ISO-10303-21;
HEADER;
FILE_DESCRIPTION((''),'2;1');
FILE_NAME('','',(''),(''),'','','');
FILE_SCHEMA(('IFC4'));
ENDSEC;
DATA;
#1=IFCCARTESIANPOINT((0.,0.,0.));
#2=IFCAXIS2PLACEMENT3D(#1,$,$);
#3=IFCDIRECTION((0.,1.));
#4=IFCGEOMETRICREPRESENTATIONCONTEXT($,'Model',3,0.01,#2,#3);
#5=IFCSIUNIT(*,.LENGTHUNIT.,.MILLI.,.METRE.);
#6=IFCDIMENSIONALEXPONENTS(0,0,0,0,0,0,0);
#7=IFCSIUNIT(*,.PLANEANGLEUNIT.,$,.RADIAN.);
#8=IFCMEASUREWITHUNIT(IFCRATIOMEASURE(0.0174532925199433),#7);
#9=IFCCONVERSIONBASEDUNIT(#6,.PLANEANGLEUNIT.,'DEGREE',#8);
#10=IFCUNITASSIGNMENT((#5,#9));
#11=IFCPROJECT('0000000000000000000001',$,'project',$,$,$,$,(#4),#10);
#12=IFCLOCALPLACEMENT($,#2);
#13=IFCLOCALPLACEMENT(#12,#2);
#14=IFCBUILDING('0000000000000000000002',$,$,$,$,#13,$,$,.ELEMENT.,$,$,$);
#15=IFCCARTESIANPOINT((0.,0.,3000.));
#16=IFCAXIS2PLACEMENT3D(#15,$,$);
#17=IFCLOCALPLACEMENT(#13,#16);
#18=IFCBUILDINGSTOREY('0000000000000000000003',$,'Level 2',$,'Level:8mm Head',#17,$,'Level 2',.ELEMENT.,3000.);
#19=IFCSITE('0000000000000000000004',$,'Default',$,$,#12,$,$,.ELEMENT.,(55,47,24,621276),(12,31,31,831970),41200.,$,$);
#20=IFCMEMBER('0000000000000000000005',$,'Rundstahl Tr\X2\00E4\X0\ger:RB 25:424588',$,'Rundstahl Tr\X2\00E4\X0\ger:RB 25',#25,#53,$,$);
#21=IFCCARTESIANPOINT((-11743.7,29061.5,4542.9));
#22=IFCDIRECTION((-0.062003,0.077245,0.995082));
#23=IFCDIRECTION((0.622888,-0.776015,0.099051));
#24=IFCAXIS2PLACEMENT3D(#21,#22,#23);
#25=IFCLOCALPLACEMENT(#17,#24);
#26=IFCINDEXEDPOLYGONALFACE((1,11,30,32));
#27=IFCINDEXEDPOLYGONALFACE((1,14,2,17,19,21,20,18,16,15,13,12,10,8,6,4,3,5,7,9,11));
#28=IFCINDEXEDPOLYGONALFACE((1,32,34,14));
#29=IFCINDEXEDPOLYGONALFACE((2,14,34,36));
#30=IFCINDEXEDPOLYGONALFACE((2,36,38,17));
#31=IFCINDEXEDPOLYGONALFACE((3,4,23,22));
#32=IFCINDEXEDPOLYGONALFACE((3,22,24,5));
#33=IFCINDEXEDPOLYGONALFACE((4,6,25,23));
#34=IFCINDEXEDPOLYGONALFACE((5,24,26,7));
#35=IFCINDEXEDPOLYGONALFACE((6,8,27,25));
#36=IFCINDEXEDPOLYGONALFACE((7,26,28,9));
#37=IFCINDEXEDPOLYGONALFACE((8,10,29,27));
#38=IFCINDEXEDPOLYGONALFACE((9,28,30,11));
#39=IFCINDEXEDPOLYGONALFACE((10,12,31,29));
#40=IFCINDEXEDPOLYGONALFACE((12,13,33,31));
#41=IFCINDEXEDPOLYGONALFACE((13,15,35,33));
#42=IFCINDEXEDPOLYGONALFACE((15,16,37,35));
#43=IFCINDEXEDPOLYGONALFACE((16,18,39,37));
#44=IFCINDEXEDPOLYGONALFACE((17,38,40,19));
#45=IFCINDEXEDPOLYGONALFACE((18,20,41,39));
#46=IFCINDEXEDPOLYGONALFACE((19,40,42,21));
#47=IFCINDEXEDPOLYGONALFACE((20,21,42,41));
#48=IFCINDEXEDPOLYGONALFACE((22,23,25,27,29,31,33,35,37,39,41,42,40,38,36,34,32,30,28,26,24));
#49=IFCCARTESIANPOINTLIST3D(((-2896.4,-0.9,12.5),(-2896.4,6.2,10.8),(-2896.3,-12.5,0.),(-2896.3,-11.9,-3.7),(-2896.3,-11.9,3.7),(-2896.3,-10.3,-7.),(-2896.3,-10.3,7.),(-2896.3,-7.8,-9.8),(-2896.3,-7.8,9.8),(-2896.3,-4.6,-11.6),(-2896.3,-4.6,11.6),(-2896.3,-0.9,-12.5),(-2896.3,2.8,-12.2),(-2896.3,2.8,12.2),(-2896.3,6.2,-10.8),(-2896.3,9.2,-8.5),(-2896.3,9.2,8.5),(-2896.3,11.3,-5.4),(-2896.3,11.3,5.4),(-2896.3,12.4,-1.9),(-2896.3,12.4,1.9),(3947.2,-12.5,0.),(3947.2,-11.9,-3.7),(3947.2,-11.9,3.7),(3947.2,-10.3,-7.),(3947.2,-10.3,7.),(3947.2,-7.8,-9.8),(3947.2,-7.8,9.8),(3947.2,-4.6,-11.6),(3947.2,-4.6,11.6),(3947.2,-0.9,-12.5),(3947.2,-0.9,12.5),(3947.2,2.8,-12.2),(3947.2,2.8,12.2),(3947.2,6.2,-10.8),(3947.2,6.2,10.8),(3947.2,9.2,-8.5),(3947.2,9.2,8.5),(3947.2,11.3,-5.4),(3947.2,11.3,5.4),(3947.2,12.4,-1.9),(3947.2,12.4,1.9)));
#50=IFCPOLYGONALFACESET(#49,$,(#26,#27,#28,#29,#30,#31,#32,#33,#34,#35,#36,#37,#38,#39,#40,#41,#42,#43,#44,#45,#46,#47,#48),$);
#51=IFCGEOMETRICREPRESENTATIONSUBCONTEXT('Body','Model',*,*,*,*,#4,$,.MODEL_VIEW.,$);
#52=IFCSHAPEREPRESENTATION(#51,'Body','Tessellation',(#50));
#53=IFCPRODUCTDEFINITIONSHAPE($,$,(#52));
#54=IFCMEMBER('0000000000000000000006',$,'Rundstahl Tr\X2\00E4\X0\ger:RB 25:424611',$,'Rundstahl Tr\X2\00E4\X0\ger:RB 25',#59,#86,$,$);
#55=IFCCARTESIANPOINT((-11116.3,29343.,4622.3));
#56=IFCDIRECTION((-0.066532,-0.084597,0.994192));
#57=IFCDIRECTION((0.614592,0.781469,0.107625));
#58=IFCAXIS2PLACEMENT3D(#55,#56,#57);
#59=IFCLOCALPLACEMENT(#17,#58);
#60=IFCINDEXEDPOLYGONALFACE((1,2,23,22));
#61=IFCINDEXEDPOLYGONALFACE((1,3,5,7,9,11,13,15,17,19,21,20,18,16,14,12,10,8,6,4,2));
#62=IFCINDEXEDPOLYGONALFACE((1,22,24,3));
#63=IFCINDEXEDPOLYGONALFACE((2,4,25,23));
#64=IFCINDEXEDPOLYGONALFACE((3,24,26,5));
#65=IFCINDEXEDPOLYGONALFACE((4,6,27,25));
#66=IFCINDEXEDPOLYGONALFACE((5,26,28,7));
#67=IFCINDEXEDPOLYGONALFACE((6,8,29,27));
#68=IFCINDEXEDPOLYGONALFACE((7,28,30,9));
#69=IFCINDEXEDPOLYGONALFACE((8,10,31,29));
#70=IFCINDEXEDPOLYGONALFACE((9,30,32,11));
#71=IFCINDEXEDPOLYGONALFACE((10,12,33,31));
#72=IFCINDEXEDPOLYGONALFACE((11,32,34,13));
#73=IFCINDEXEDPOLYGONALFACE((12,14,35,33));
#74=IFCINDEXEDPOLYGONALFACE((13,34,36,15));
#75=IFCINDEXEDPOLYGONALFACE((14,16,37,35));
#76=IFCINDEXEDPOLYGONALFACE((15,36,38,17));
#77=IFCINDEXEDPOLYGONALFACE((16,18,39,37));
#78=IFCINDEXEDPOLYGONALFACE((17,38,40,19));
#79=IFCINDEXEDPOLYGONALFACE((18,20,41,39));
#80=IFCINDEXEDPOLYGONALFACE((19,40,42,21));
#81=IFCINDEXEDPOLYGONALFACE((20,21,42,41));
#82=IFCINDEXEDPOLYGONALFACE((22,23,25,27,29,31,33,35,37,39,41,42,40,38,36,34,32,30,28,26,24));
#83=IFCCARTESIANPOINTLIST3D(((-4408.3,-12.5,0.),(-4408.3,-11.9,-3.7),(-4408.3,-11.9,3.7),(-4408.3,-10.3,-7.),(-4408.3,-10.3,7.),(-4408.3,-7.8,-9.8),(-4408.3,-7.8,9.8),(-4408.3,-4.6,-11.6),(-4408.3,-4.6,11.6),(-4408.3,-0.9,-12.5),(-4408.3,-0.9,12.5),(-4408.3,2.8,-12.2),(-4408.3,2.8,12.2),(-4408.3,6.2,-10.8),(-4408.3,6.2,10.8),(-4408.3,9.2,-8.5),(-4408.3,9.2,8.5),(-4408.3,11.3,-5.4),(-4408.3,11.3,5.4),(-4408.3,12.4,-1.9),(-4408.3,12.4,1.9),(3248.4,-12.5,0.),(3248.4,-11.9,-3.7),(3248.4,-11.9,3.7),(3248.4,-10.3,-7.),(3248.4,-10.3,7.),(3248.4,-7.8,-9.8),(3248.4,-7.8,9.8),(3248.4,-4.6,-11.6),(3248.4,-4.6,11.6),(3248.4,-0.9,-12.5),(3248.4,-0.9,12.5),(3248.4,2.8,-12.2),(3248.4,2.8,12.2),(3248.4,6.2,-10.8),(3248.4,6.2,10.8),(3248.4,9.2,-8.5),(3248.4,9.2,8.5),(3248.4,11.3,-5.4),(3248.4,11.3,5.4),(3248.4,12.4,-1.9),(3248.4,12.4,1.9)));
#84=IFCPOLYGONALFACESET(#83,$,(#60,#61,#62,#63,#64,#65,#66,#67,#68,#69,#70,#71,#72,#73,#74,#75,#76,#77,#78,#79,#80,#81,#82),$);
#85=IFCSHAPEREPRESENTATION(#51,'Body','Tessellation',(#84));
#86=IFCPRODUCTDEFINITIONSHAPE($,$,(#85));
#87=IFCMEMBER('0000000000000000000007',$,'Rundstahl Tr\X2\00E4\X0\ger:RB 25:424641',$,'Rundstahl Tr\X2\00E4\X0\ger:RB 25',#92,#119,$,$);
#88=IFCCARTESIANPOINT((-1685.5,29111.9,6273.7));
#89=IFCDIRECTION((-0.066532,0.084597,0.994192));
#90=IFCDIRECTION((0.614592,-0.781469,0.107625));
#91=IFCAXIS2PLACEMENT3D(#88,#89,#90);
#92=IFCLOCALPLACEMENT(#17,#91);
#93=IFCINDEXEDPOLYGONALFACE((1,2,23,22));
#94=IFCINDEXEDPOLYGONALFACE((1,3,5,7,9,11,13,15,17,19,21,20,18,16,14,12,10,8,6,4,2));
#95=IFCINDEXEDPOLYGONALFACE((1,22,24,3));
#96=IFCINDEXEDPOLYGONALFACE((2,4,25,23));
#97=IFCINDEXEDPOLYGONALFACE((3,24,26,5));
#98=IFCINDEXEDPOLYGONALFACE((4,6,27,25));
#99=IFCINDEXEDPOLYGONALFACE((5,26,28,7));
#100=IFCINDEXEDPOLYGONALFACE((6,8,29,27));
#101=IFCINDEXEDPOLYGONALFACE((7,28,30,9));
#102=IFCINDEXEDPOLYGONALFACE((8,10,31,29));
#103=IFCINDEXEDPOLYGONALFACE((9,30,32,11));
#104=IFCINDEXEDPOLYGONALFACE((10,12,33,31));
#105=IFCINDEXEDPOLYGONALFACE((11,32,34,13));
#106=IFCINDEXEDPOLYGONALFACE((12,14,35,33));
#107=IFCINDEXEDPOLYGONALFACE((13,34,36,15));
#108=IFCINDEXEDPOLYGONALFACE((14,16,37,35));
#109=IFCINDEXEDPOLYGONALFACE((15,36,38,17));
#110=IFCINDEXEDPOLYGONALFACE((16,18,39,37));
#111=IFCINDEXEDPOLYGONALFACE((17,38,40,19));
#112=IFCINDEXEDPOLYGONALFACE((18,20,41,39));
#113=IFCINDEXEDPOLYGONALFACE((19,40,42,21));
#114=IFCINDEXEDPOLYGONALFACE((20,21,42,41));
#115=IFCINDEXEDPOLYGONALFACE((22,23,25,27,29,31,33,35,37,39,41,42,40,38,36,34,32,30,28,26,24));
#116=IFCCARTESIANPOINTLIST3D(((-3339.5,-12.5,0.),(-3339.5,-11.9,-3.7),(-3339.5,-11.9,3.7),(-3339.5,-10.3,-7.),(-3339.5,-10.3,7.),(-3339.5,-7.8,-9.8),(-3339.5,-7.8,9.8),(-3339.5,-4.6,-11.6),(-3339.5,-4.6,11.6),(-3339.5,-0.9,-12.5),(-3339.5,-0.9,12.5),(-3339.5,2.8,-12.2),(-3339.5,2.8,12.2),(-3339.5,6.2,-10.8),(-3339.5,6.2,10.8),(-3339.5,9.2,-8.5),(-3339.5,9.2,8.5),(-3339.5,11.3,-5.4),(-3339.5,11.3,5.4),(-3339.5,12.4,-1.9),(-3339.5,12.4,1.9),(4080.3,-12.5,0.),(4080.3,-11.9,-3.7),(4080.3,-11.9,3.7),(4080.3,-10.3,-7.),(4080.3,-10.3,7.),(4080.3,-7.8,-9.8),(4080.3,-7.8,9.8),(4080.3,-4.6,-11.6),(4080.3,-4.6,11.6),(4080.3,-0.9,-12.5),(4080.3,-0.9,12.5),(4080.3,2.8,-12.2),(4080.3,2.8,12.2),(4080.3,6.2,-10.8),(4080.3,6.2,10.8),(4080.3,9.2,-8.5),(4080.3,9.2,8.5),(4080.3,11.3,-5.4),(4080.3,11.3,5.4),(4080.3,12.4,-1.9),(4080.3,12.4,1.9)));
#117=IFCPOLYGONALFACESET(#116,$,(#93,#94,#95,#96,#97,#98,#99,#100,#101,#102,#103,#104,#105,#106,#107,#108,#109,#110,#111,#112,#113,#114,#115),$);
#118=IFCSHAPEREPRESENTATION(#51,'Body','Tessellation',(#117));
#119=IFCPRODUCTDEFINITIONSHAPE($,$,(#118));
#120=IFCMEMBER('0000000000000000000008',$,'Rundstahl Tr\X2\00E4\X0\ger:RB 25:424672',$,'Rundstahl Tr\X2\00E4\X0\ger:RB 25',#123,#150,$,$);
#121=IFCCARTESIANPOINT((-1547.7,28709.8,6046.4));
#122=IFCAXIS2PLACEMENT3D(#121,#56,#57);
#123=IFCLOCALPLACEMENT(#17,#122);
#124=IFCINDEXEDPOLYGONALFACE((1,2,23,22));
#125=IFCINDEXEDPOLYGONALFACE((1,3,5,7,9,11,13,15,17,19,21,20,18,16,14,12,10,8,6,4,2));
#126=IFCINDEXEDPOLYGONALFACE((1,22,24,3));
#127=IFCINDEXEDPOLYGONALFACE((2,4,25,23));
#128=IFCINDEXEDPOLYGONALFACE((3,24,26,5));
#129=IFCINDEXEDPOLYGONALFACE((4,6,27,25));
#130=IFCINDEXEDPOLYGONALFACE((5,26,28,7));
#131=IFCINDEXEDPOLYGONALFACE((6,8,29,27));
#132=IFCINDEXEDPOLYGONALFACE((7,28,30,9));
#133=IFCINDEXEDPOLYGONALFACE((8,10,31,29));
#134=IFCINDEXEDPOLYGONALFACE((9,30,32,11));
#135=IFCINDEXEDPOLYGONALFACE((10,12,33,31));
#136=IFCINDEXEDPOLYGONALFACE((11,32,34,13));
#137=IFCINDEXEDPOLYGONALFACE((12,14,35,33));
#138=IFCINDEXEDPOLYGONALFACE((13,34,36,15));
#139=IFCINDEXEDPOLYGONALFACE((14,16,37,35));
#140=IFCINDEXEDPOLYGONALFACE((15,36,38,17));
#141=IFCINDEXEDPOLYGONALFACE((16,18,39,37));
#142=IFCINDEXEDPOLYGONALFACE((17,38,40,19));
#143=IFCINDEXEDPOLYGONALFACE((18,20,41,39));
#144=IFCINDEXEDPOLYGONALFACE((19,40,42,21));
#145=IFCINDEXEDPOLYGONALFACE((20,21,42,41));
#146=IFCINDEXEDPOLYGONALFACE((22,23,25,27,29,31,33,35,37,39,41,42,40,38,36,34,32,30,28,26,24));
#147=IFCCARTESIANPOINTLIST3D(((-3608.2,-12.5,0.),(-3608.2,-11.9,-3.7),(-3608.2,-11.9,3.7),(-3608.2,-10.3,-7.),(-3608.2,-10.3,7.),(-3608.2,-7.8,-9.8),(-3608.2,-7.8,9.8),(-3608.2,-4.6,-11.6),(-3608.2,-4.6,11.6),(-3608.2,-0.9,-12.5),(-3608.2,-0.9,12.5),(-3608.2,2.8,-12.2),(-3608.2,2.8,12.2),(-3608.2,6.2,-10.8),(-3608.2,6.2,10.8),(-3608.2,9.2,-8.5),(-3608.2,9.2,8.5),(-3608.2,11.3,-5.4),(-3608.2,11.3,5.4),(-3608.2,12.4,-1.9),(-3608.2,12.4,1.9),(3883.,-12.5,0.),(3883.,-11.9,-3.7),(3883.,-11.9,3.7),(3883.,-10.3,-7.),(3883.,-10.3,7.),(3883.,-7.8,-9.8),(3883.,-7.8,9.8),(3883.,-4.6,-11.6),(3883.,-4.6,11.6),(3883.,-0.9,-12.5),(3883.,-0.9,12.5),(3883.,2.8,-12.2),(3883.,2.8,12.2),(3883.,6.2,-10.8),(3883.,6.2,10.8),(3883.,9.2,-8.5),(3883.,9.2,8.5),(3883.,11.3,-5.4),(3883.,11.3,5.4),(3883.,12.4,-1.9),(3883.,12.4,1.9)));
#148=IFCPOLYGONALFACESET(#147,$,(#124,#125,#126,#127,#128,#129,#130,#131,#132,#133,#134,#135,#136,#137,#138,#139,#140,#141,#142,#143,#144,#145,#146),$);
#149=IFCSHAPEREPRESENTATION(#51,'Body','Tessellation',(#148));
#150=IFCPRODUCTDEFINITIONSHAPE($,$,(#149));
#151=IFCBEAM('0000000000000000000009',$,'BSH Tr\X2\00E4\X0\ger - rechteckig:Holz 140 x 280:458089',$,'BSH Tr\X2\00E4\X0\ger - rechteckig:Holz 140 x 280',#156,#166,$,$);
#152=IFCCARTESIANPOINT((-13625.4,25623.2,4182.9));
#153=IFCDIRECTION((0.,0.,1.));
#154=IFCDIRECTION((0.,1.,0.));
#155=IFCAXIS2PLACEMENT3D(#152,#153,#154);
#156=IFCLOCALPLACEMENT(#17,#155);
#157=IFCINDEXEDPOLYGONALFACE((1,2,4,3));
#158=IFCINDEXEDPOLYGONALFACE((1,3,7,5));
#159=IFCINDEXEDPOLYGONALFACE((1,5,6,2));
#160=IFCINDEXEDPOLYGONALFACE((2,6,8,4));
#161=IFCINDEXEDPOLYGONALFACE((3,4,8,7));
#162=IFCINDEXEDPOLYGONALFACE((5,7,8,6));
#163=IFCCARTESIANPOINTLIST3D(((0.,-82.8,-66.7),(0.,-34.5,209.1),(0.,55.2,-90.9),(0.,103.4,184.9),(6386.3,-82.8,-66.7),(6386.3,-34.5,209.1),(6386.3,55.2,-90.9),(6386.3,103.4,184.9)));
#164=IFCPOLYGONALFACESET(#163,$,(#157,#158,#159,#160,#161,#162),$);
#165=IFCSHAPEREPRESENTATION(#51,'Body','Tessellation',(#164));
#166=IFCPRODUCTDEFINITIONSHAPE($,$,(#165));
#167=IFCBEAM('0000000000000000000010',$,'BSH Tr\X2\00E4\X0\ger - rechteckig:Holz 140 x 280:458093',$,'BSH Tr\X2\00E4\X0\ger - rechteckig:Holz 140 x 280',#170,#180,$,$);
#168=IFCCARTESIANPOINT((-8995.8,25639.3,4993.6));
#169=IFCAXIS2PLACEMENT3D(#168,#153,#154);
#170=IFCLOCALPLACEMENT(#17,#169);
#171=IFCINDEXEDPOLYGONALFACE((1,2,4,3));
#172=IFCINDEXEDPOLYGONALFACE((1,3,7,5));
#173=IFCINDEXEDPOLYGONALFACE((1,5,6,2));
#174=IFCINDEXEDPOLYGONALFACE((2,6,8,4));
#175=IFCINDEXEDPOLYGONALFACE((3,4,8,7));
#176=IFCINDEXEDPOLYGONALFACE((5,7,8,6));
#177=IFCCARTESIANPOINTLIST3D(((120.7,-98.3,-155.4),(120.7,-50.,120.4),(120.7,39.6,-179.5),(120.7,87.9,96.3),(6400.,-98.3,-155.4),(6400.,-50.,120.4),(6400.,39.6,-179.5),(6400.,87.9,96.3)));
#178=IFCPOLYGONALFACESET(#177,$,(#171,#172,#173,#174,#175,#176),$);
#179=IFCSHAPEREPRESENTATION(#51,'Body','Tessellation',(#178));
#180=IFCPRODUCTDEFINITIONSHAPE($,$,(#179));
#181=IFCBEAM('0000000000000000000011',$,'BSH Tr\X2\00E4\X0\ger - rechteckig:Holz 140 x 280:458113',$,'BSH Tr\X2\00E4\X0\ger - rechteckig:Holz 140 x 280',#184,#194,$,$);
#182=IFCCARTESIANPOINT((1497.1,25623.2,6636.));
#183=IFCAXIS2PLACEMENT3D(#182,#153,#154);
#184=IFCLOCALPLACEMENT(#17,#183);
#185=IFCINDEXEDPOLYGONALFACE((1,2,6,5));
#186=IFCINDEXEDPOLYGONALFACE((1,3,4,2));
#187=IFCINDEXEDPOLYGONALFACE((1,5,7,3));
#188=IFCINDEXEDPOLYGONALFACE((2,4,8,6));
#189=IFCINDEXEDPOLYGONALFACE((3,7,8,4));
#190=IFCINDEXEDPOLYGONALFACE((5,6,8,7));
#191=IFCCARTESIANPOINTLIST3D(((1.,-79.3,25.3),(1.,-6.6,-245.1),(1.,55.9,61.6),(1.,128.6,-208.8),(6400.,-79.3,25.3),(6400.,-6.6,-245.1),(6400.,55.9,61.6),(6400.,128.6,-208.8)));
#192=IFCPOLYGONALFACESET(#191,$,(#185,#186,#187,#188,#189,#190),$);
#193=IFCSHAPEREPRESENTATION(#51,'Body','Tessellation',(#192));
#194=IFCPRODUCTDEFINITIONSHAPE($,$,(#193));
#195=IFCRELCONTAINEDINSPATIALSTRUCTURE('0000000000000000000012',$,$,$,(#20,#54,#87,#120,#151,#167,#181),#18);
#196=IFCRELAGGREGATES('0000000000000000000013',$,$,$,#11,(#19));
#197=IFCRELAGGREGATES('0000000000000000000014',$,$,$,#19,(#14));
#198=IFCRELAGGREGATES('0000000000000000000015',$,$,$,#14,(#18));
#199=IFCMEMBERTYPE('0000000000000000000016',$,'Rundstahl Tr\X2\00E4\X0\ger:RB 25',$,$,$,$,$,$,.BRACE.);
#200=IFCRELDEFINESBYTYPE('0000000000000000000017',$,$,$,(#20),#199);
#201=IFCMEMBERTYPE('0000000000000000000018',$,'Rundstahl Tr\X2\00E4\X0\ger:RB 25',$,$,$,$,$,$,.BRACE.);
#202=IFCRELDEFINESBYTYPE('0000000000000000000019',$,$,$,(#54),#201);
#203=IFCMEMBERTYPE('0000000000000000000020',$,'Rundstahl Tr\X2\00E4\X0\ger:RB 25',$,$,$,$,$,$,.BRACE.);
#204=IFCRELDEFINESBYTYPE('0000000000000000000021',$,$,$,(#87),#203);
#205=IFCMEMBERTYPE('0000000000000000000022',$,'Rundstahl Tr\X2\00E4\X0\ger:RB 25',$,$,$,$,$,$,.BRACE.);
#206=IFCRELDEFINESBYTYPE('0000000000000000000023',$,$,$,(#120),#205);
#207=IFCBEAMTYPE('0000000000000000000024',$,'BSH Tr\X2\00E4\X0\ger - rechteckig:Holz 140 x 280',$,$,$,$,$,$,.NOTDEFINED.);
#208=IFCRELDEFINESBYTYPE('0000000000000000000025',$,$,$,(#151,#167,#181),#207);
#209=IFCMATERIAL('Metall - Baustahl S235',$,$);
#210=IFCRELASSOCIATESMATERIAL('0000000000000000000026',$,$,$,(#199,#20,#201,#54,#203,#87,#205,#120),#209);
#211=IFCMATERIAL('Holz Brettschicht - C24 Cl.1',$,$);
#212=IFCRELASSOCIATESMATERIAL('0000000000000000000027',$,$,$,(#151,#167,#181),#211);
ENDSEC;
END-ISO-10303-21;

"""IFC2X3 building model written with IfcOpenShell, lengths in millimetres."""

from ifc_helpers import new_model, entity, si_unit, converted_unit, direction, frame, frame_2d, origin, origin_2d_with_axis, place, context, subcontext, project, spatial, rectangle, circle, extrude, source, transform, mapped, material, type_object, type_shapes, element, save


model = new_model("IFC2X3")

# Units and contexts
model_context = context("Model", 3, precision=0.01, world=origin(), true_north=direction((0.0, 1.0)))
body_context = subcontext(model_context, "Body", "Model", "MODEL_VIEW")
ifc_project = project(units=[si_unit("LENGTHUNIT", "METRE", prefix="MILLI"), converted_unit("PLANEANGLEUNIT", "DEGREE", entity("IfcRatioMeasure", 0.0174532925199433), si_unit("PLANEANGLEUNIT", "RADIAN"), dimensions=[0, 0, 0, 0, 0, 0, 0])], contexts=[model_context])

# Site, building, storey
site_placement = place(None, origin())
site = spatial("IfcSite", under=ifc_project, at=site_placement, Name="Default", CompositionType="ELEMENT", RefLatitude=(55, 47, 24, 621276), RefLongitude=(12, 31, 31, 831970), RefElevation=41200.0)
building_placement = place(site_placement, origin())
building = spatial("IfcBuilding", under=site, at=building_placement, CompositionType="ELEMENT")
storey_placement = place(building_placement, frame((0.0, 0.0, 3000.0)))
storey = spatial("IfcBuildingStorey", under=building, at=storey_placement, Name="Level 2", ObjectType="Level:8mm Head", LongName="Level 2", CompositionType="ELEMENT", Elevation=3000.0)

# Shared definitions
ifc_material_1 = material(Name="Holz Brettschicht - C24 Cl.1")
ifc_material_2 = material(Name="Metall - Baustahl S235")

# Members
member_type_1 = type_object("IfcMemberType", Name="Rundstahl Träger:RB 25", PredefinedType="BRACE", material=ifc_material_2)
shared_shape_1 = source(origin(), body_context, "Body", "SweptSolid", [
    extrude(circle(Radius=12.5, at=frame_2d((0.0, 0.0), x_axis=(1.0, 0.0))), frame((-2896.3, 0.0, 0.0), z_axis=(1.0, 0.0, 0.0), x_axis=(0.0, -1.0, 0.0)), (0.0, 0.0, 1.0), 6843.6),
])
type_shapes(member_type_1, [shared_shape_1])
member_1_placement = place(storey_placement, frame((-11743.7, 29061.5, 4542.9), z_axis=(-0.062003, 0.077245, 0.995082), x_axis=(0.622888, -0.776015, 0.099051)))
element("IfcMember", 1, at=member_1_placement, inside=storey, type_object=member_type_1, material=ifc_material_2, Name="Rundstahl Träger:RB 25:424588", ObjectType="Rundstahl Träger:RB 25", context=body_context, shape_type="MappedRepresentation", body=[
    mapped(shared_shape_1, transform((0.0, 0.0, 0.0), scale=1.0)),
])
member_type_2 = type_object("IfcMemberType", Name="Rundstahl Träger:RB 25", PredefinedType="BRACE", material=ifc_material_2)
shared_shape_2 = source(origin(), body_context, "Body", "SweptSolid", [
    extrude(circle(Radius=12.5, at=frame_2d((0.0, 0.0), x_axis=(1.0, 0.0))), frame((-4408.3, 0.0, 0.0), z_axis=(1.0, 0.0, 0.0), x_axis=(0.0, -1.0, 0.0)), (0.0, 0.0, 1.0), 7656.7),
])
type_shapes(member_type_2, [shared_shape_2])
member_2_placement = place(storey_placement, frame((-11116.3, 29343.0, 4622.3), z_axis=(-0.066532, -0.084597, 0.994192), x_axis=(0.614592, 0.781469, 0.107625)))
element("IfcMember", 2, at=member_2_placement, inside=storey, type_object=member_type_2, material=ifc_material_2, Name="Rundstahl Träger:RB 25:424611", ObjectType="Rundstahl Träger:RB 25", context=body_context, shape_type="MappedRepresentation", body=[
    mapped(shared_shape_2, transform((0.0, 0.0, 0.0), scale=1.0)),
])
member_type_3 = type_object("IfcMemberType", Name="Rundstahl Träger:RB 25", PredefinedType="BRACE", material=ifc_material_2)
shared_shape_3 = source(origin(), body_context, "Body", "SweptSolid", [
    extrude(circle(Radius=12.5, at=frame_2d((0.0, 0.0), x_axis=(1.0, 0.0))), frame((-3339.5, 0.0, 0.0), z_axis=(1.0, 0.0, 0.0), x_axis=(0.0, -1.0, 0.0)), (0.0, 0.0, 1.0), 7419.7),
])
type_shapes(member_type_3, [shared_shape_3])
member_3_placement = place(storey_placement, frame((-1685.5, 29111.9, 6273.7), z_axis=(-0.066532, 0.084597, 0.994192), x_axis=(0.614592, -0.781469, 0.107625)))
element("IfcMember", 3, at=member_3_placement, inside=storey, type_object=member_type_3, material=ifc_material_2, Name="Rundstahl Träger:RB 25:424641", ObjectType="Rundstahl Träger:RB 25", context=body_context, shape_type="MappedRepresentation", body=[
    mapped(shared_shape_3, transform((0.0, 0.0, 0.0), scale=1.0)),
])
member_type_4 = type_object("IfcMemberType", Name="Rundstahl Träger:RB 25", PredefinedType="BRACE", material=ifc_material_2)
shared_shape_4 = source(origin(), body_context, "Body", "SweptSolid", [
    extrude(circle(Radius=12.5, at=frame_2d((0.0, 0.0), x_axis=(1.0, 0.0))), frame((-3608.2, 0.0, 0.0), z_axis=(1.0, 0.0, 0.0), x_axis=(0.0, -1.0, 0.0)), (0.0, 0.0, 1.0), 7491.1),
])
type_shapes(member_type_4, [shared_shape_4])
member_4_placement = place(storey_placement, frame((-1547.7, 28709.8, 6046.4), z_axis=(-0.066532, -0.084597, 0.994192), x_axis=(0.614592, 0.781469, 0.107625)))
element("IfcMember", 4, at=member_4_placement, inside=storey, type_object=member_type_4, material=ifc_material_2, Name="Rundstahl Träger:RB 25:424672", ObjectType="Rundstahl Träger:RB 25", context=body_context, shape_type="MappedRepresentation", body=[
    mapped(shared_shape_4, transform((0.0, 0.0, 0.0), scale=1.0)),
])

# Beams
beam_type_1 = type_object("IfcBeamType", Name="BSH Träger - rechteckig:Holz 140 x 280", PredefinedType="NOTDEFINED")
beam_1_placement = place(storey_placement, frame((-13625.4, 25623.2, 4182.9), z_axis=(0.0, 0.0, 1.0), x_axis=(0.0, 1.0, 0.0)))
element("IfcBeam", 5, at=beam_1_placement, inside=storey, type_object=beam_type_1, material=ifc_material_1, Name="BSH Träger - rechteckig:Holz 140 x 280:458089", ObjectType="BSH Träger - rechteckig:Holz 140 x 280", context=body_context, shape_type="SweptSolid", body=[
    extrude(rectangle(XDim=280.0, YDim=140.0, at=origin_2d_with_axis()), frame((0.0, 10.3, 59.1), z_axis=(1.0, 0.0, 0.0), x_axis=(0.0, 0.172491, 0.985011)), (0.0, 0.0, 1.0), 6386.3),
])
beam_2_placement = place(storey_placement, frame((-8995.8, 25639.3, 4993.6), z_axis=(0.0, 0.0, 1.0), x_axis=(0.0, 1.0, 0.0)))
element("IfcBeam", 6, at=beam_2_placement, inside=storey, type_object=beam_type_1, material=ifc_material_1, Name="BSH Träger - rechteckig:Holz 140 x 280:458093", ObjectType="BSH Träger - rechteckig:Holz 140 x 280", context=body_context, shape_type="SweptSolid", body=[
    extrude(rectangle(XDim=280.0, YDim=140.0, at=frame_2d((0.0, 0.0), x_axis=(1.0, 0.0))), frame((120.7, -5.2, -29.6), z_axis=(1.0, 0.0, 0.0), x_axis=(0.0, 0.172491, 0.985011)), (0.0, 0.0, 1.0), 6279.3),
])
beam_3_placement = place(storey_placement, frame((1497.1, 25623.2, 6636.0), z_axis=(0.0, 0.0, 1.0), x_axis=(0.0, 1.0, 0.0)))
element("IfcBeam", 7, at=beam_3_placement, inside=storey, type_object=beam_type_1, material=ifc_material_1, Name="BSH Träger - rechteckig:Holz 140 x 280:458113", ObjectType="BSH Träger - rechteckig:Holz 140 x 280", context=body_context, shape_type="SweptSolid", body=[
    extrude(rectangle(XDim=280.0, YDim=140.0, at=frame_2d((0.0, 0.0), x_axis=(1.0, 0.0))), frame((1.0, 24.7, -91.7), z_axis=(1.0, 0.0, 0.0), x_axis=(0.0, -0.259528, 0.965735)), (0.0, 0.0, 1.0), 6399.0),
])

save(model, "model.ifc")
